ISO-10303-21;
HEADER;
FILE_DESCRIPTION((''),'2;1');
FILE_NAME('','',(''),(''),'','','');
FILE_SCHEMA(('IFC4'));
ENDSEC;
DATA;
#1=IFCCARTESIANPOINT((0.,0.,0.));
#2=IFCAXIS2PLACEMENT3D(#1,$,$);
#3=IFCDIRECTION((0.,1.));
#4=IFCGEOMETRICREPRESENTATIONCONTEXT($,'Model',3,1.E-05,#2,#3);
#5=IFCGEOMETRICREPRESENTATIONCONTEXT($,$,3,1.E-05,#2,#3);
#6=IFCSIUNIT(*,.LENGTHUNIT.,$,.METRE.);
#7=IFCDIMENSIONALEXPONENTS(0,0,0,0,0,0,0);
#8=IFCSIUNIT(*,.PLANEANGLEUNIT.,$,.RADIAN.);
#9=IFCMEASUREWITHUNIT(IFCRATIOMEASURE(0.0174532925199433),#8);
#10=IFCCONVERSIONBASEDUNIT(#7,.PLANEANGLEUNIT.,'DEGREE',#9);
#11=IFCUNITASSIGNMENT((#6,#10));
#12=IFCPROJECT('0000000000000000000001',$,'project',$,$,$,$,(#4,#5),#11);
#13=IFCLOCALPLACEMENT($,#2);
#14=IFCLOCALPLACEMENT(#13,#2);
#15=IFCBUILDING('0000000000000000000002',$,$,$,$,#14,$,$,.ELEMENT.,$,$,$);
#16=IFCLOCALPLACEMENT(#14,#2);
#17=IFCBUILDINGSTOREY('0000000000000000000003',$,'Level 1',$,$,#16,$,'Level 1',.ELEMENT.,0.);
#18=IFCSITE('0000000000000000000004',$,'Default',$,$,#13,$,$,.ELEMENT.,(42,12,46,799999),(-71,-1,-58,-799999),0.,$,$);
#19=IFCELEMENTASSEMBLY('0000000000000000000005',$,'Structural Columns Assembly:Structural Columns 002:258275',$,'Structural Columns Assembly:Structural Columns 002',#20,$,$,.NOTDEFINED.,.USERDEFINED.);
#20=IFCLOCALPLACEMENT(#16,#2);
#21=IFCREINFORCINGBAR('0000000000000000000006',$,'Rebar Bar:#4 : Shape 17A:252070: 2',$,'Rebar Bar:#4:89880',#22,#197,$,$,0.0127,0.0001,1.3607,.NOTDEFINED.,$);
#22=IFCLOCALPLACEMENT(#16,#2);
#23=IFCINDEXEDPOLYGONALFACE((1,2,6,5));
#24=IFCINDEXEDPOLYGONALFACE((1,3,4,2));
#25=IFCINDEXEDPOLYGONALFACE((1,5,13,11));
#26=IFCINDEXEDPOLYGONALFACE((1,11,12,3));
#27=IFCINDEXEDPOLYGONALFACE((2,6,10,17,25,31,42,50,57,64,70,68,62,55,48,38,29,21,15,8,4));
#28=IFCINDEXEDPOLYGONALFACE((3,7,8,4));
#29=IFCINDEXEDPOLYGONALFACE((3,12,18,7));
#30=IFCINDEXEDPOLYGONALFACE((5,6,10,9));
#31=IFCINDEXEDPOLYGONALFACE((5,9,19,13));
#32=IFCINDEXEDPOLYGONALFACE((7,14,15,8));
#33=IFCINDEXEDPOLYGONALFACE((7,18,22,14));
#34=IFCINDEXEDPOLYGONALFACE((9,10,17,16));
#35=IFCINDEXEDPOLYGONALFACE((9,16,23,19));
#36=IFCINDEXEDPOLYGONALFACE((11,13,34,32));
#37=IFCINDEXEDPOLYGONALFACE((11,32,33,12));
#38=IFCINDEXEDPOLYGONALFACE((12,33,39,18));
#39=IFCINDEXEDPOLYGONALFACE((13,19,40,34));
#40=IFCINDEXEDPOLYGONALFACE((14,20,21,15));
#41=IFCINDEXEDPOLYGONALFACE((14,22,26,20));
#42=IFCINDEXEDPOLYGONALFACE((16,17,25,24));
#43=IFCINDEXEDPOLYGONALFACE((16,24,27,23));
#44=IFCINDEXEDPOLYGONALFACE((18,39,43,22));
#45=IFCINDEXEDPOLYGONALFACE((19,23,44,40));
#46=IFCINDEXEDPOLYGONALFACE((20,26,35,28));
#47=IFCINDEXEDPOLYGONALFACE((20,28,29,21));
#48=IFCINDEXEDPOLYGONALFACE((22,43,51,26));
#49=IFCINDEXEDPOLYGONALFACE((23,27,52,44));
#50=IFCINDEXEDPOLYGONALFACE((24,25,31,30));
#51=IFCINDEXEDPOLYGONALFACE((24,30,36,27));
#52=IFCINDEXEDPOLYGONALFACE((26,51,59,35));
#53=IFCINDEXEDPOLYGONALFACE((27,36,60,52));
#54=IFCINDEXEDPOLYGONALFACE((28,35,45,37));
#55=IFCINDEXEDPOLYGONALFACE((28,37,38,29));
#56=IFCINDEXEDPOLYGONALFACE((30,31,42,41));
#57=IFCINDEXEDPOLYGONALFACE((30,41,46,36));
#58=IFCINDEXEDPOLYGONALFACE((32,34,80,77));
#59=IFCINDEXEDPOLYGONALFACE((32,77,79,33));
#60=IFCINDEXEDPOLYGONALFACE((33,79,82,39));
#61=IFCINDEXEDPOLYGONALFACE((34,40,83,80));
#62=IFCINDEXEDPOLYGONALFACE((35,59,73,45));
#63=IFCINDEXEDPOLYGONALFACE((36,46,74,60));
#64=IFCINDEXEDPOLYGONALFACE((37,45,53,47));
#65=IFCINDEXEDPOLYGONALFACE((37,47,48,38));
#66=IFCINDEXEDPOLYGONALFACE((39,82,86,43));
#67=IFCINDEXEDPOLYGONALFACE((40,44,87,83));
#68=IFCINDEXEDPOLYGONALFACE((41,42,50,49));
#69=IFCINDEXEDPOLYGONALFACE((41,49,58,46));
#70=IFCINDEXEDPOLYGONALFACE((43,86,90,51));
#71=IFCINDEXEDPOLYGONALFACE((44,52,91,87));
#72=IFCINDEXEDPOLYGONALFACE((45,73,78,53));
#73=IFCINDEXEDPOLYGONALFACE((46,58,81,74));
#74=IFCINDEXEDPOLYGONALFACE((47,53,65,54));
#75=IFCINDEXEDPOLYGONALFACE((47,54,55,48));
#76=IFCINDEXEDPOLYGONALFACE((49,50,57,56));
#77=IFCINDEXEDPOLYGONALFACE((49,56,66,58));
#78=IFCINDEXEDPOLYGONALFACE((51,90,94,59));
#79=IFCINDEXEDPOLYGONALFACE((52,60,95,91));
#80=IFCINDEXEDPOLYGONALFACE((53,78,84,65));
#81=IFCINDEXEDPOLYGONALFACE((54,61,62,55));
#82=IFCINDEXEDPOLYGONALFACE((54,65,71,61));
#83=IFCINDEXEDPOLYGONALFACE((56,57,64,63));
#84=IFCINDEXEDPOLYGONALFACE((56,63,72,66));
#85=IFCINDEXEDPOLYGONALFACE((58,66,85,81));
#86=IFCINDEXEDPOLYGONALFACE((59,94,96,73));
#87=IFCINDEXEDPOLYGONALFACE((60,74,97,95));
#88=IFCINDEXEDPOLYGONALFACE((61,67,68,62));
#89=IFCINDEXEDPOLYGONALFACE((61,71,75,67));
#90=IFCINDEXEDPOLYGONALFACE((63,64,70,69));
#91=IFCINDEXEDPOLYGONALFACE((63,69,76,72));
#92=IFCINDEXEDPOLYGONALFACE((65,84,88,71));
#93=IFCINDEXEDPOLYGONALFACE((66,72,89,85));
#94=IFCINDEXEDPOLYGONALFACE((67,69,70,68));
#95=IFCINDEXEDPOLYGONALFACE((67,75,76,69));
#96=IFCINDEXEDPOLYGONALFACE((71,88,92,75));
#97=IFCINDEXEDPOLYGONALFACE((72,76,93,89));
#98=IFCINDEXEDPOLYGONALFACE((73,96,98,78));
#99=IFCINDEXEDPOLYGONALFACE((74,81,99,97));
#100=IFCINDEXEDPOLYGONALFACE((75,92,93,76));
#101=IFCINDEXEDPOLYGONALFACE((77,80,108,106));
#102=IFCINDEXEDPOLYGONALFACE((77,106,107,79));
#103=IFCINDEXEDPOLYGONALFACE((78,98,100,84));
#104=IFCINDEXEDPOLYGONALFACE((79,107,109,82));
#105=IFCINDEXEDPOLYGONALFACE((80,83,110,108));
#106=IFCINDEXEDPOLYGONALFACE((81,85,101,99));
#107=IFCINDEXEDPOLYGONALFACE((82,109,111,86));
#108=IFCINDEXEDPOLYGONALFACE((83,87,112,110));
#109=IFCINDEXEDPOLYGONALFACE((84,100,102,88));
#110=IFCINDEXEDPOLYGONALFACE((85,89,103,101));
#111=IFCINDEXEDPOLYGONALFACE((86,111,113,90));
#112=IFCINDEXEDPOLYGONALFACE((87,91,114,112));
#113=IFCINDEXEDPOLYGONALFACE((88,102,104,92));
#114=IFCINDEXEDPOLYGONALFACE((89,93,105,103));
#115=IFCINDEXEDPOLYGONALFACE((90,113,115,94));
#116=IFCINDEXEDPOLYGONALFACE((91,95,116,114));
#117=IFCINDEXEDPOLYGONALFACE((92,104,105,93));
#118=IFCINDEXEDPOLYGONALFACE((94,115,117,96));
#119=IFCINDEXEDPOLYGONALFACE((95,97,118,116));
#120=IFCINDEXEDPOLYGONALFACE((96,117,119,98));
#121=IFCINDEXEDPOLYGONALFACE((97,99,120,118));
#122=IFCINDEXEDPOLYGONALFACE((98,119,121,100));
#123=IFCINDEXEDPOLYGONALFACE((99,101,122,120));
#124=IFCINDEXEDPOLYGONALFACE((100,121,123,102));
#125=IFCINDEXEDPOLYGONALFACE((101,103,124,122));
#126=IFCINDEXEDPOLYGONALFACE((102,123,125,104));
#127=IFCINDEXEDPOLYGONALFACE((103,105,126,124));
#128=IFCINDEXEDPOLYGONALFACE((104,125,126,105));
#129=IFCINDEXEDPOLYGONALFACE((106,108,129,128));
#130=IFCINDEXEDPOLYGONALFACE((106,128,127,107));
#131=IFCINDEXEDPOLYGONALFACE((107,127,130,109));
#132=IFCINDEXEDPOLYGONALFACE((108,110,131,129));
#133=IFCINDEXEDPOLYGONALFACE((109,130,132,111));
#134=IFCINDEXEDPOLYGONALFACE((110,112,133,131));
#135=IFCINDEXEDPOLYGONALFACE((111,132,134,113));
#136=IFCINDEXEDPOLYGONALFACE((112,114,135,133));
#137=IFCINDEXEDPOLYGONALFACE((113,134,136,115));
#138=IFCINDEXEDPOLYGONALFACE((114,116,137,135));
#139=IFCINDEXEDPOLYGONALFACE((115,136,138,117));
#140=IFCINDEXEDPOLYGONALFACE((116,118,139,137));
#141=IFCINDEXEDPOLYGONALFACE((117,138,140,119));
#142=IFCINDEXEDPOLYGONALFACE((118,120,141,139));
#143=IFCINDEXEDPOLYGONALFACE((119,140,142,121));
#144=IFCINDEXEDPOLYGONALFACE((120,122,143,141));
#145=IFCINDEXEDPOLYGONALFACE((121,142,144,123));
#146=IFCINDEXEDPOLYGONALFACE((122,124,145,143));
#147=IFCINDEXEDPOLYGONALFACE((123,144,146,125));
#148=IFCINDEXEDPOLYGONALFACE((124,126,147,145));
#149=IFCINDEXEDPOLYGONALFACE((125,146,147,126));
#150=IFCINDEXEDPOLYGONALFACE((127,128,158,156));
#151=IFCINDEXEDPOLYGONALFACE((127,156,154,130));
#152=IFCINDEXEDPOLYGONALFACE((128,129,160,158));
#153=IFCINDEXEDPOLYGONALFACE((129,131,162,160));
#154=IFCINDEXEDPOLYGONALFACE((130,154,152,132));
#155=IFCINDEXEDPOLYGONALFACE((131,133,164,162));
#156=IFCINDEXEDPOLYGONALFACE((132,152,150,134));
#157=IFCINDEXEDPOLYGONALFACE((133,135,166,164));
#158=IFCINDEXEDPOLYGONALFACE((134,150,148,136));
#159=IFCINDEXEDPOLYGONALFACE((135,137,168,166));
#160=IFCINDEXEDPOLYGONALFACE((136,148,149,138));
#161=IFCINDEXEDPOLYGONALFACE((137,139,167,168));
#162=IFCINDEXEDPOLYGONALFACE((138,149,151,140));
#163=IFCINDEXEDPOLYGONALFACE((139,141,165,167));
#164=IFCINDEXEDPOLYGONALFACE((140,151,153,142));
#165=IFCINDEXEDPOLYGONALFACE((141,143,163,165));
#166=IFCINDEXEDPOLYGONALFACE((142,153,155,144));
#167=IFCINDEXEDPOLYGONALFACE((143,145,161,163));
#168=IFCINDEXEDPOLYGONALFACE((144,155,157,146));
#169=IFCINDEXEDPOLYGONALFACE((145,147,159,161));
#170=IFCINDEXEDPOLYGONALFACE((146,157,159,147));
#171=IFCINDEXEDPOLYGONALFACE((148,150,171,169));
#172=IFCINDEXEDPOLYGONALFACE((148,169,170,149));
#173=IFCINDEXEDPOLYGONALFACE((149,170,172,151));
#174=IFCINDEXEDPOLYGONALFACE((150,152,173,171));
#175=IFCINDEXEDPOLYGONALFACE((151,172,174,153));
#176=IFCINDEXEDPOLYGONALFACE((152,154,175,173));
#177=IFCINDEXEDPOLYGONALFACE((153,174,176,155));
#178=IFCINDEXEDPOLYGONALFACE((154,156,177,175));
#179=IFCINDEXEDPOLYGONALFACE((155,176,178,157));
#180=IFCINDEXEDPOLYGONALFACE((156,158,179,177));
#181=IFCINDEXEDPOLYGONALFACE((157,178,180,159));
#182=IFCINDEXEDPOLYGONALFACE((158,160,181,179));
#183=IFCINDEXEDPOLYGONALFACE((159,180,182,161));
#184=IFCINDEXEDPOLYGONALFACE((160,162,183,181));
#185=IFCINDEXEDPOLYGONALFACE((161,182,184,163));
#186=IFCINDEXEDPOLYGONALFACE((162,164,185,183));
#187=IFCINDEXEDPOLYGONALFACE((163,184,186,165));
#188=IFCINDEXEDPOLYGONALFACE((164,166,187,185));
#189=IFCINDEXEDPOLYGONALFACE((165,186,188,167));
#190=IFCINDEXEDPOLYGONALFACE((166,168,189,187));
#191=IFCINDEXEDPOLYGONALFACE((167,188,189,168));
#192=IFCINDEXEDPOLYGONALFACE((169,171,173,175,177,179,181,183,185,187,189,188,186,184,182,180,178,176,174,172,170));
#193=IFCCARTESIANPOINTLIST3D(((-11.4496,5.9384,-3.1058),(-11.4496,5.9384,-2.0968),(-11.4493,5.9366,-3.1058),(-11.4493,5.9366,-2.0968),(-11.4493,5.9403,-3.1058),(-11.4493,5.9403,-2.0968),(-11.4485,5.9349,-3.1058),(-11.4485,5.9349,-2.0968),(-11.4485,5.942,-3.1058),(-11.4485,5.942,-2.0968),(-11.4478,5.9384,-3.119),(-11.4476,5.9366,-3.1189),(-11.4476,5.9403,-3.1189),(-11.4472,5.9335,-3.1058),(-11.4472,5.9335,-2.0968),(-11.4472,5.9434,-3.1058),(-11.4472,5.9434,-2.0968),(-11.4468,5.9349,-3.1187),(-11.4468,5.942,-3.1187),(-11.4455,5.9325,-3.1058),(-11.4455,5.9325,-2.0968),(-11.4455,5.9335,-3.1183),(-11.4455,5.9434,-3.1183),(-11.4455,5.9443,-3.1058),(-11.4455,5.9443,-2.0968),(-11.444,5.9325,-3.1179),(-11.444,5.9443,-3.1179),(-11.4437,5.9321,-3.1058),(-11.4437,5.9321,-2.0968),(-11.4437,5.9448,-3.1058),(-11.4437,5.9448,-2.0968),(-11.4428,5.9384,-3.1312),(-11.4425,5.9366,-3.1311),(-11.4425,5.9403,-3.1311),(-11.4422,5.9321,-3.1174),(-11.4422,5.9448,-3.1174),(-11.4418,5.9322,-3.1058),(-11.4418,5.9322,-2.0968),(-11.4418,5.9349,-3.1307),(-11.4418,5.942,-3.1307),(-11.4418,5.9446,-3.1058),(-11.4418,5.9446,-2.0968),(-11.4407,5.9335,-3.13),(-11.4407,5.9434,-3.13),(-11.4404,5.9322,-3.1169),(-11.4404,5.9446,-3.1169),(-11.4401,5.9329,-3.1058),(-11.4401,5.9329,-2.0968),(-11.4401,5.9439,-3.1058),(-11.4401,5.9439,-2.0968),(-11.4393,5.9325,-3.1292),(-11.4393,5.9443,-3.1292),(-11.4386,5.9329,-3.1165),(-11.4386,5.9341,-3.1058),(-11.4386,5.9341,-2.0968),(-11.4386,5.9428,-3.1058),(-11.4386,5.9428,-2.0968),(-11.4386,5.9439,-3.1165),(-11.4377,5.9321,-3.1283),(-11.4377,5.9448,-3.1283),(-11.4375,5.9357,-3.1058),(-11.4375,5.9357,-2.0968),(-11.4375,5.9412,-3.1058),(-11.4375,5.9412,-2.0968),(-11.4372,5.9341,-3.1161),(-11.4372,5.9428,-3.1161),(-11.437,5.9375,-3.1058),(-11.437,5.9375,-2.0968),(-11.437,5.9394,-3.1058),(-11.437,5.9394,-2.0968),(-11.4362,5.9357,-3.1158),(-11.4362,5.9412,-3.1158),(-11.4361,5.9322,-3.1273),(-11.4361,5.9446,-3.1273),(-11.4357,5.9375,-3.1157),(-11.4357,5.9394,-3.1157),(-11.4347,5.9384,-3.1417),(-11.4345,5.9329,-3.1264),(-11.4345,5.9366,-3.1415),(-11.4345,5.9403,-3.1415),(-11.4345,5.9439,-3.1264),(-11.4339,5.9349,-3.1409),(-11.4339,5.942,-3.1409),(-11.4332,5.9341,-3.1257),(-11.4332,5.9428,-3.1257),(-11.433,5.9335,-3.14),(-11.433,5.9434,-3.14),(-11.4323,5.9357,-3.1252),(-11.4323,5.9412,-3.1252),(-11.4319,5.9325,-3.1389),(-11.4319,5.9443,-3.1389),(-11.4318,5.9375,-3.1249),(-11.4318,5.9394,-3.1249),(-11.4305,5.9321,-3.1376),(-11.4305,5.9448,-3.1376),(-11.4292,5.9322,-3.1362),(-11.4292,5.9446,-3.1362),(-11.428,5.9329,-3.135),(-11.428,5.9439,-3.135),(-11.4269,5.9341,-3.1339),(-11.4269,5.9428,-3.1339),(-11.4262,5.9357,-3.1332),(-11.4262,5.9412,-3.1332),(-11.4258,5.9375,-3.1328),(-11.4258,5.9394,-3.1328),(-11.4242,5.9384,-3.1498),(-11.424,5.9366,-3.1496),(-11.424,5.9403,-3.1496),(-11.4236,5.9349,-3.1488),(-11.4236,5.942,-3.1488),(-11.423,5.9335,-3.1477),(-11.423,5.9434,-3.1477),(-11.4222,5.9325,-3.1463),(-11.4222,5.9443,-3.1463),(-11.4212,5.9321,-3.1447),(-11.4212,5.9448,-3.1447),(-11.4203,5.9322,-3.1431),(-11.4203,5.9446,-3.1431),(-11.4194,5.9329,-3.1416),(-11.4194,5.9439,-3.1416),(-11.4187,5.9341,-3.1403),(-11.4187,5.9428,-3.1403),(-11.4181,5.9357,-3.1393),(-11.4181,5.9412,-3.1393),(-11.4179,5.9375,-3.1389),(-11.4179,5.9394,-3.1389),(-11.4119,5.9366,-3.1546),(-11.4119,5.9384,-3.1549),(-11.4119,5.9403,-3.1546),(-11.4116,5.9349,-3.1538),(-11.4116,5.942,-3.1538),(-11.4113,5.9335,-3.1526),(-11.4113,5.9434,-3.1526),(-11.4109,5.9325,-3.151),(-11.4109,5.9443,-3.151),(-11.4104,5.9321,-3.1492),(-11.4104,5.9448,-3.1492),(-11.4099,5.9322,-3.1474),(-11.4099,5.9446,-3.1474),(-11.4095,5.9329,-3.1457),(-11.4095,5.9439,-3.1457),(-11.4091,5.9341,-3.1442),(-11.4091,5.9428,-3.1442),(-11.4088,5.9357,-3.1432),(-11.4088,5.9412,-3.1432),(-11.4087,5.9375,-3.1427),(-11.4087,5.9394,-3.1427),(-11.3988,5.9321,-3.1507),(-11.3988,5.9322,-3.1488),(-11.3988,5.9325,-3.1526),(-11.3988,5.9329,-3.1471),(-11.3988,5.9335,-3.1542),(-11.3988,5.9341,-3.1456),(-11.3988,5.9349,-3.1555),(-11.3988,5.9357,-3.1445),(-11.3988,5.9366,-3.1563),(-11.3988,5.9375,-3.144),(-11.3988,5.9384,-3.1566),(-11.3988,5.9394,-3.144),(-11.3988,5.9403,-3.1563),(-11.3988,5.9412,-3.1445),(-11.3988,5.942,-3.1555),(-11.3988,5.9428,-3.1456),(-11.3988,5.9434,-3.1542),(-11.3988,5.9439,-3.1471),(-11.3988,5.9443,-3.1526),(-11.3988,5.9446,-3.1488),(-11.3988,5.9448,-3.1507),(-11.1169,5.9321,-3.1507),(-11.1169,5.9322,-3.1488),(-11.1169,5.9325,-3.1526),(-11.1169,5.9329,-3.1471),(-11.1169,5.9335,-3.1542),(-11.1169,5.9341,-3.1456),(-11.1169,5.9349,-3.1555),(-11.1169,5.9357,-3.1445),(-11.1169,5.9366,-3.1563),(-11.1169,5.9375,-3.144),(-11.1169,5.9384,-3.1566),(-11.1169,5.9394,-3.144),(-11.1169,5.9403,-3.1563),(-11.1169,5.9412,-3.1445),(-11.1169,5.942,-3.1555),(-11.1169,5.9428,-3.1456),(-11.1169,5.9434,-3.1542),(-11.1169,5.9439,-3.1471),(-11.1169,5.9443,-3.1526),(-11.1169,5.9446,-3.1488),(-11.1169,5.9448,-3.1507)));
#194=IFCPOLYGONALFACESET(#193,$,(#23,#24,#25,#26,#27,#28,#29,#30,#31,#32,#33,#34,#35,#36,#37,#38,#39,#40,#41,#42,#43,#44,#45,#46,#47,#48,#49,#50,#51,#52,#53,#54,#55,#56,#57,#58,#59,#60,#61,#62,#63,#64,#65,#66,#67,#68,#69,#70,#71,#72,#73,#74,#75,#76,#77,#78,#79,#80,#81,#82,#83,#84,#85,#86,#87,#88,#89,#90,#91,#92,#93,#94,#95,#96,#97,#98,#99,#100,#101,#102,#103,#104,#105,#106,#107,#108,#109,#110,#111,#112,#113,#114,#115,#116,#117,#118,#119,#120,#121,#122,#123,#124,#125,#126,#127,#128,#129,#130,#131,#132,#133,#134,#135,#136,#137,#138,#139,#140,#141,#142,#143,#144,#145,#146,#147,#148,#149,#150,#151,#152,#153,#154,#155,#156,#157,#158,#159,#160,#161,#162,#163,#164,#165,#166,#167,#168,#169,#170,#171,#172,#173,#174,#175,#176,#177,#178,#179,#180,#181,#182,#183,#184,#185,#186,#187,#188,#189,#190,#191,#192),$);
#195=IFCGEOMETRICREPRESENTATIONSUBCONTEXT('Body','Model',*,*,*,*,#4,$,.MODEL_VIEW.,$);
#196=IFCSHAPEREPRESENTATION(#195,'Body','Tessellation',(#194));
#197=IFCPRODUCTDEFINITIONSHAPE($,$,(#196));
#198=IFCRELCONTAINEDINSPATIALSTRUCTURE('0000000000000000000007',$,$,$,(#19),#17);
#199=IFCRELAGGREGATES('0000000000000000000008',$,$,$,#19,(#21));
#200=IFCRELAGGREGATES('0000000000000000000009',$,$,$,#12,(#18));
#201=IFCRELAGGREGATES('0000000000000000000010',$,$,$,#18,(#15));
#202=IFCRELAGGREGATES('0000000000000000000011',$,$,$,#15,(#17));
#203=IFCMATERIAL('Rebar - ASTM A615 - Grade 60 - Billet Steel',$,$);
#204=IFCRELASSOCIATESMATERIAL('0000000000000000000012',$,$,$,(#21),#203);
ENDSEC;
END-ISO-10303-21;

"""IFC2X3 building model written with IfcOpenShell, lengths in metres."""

from ifc_helpers import new_model, entity, si_unit, converted_unit, direction, origin, place, context, subcontext, project, spatial, material, element, aggregate, save


model = new_model("IFC2X3")

# Units and contexts
model_context = context("Model", 3, precision=1e-05, world=origin(), true_north=direction((0.0, 1.0)))
context_of_model = context(None, 3, precision=1e-05, world=origin(), true_north=direction((0.0, 1.0)))
body_context = subcontext(model_context, "Body", "Model", "MODEL_VIEW")
ifc_project = project(units=[si_unit("LENGTHUNIT", "METRE"), converted_unit("PLANEANGLEUNIT", "DEGREE", entity("IfcRatioMeasure", 0.0174532925199433), si_unit("PLANEANGLEUNIT", "RADIAN"), dimensions=[0, 0, 0, 0, 0, 0, 0])], contexts=[model_context, context_of_model])

# Site, building, storey
site_placement = place(None, origin())
site = spatial("IfcSite", under=ifc_project, at=site_placement, Name="Default", CompositionType="ELEMENT", RefLatitude=(42, 12, 46, 799999), RefLongitude=(-71, -1, -58, -799999), RefElevation=0.0)
building_placement = place(site_placement, origin())
building = spatial("IfcBuilding", under=site, at=building_placement, CompositionType="ELEMENT")
storey_placement = place(building_placement, origin())
storey = spatial("IfcBuildingStorey", under=building, at=storey_placement, Name="Level 1", LongName="Level 1", CompositionType="ELEMENT", Elevation=0.0)

# Element assembly, reinforcing bar
assembly_1_placement = place(storey_placement, origin())
assembly_1 = element("IfcElementAssembly", 1, at=assembly_1_placement, inside=storey, Name="Structural Columns Assembly:Structural Columns 002:258275", ObjectType="Structural Columns Assembly:Structural Columns 002", AssemblyPlace="NOTDEFINED", PredefinedType="USERDEFINED")
ifc_material_1 = material(Name="Rebar - ASTM A615 - Grade 60 - Billet Steel")
reinforcing_bar_1_placement = place(assembly_1_placement, origin())
reinforcing_bar_1 = element("IfcReinforcingBar", 2, at=reinforcing_bar_1_placement, material=ifc_material_1, Name="Rebar Bar:#4 : Shape 17A:252070: 2", ObjectType="Rebar Bar:#4:89880", BarLength=1.3607, BarRole="NOTDEFINED", CrossSectionArea=0.0001, NominalDiameter=0.0127, context=body_context, shape_type="AdvancedSweptSolid", body=[
    entity("IfcSweptDiskSolid", entity("IfcCompositeCurve", [entity("IfcCompositeCurveSegment", "CONTINUOUS", True, entity("IfcPolyline", [entity("IfcCartesianPoint", [-11.4432, 5.9384, -2.0968]), entity("IfcCartesianPoint", [-11.4432, 5.9384, -3.1058])])), entity("IfcCompositeCurveSegment", "CONTINUOUS", True, entity("IfcTrimmedCurve", entity("IfcCircle", entity("IfcAxis2Placement3D", entity("IfcCartesianPoint", [-11.3988, 5.9384, -3.1058]), entity("IfcDirection", [0.0, -1.0, 0.0]), entity("IfcDirection", [0.0, 0.0, -1.0])), 0.0445), [entity("IfcParameterValue", 270.0)], [entity("IfcParameterValue", 360.0)], True, "PARAMETER")), entity("IfcCompositeCurveSegment", "CONTINUOUS", True, entity("IfcPolyline", [entity("IfcCartesianPoint", [-11.3988, 5.9384, -3.1503]), entity("IfcCartesianPoint", [-11.1169, 5.9384, -3.1503])]))], False), 0.0063, None, 0.0, 92.0),
])
aggregate(assembly_1, [reinforcing_bar_1])

save(model, "model.ifc")
